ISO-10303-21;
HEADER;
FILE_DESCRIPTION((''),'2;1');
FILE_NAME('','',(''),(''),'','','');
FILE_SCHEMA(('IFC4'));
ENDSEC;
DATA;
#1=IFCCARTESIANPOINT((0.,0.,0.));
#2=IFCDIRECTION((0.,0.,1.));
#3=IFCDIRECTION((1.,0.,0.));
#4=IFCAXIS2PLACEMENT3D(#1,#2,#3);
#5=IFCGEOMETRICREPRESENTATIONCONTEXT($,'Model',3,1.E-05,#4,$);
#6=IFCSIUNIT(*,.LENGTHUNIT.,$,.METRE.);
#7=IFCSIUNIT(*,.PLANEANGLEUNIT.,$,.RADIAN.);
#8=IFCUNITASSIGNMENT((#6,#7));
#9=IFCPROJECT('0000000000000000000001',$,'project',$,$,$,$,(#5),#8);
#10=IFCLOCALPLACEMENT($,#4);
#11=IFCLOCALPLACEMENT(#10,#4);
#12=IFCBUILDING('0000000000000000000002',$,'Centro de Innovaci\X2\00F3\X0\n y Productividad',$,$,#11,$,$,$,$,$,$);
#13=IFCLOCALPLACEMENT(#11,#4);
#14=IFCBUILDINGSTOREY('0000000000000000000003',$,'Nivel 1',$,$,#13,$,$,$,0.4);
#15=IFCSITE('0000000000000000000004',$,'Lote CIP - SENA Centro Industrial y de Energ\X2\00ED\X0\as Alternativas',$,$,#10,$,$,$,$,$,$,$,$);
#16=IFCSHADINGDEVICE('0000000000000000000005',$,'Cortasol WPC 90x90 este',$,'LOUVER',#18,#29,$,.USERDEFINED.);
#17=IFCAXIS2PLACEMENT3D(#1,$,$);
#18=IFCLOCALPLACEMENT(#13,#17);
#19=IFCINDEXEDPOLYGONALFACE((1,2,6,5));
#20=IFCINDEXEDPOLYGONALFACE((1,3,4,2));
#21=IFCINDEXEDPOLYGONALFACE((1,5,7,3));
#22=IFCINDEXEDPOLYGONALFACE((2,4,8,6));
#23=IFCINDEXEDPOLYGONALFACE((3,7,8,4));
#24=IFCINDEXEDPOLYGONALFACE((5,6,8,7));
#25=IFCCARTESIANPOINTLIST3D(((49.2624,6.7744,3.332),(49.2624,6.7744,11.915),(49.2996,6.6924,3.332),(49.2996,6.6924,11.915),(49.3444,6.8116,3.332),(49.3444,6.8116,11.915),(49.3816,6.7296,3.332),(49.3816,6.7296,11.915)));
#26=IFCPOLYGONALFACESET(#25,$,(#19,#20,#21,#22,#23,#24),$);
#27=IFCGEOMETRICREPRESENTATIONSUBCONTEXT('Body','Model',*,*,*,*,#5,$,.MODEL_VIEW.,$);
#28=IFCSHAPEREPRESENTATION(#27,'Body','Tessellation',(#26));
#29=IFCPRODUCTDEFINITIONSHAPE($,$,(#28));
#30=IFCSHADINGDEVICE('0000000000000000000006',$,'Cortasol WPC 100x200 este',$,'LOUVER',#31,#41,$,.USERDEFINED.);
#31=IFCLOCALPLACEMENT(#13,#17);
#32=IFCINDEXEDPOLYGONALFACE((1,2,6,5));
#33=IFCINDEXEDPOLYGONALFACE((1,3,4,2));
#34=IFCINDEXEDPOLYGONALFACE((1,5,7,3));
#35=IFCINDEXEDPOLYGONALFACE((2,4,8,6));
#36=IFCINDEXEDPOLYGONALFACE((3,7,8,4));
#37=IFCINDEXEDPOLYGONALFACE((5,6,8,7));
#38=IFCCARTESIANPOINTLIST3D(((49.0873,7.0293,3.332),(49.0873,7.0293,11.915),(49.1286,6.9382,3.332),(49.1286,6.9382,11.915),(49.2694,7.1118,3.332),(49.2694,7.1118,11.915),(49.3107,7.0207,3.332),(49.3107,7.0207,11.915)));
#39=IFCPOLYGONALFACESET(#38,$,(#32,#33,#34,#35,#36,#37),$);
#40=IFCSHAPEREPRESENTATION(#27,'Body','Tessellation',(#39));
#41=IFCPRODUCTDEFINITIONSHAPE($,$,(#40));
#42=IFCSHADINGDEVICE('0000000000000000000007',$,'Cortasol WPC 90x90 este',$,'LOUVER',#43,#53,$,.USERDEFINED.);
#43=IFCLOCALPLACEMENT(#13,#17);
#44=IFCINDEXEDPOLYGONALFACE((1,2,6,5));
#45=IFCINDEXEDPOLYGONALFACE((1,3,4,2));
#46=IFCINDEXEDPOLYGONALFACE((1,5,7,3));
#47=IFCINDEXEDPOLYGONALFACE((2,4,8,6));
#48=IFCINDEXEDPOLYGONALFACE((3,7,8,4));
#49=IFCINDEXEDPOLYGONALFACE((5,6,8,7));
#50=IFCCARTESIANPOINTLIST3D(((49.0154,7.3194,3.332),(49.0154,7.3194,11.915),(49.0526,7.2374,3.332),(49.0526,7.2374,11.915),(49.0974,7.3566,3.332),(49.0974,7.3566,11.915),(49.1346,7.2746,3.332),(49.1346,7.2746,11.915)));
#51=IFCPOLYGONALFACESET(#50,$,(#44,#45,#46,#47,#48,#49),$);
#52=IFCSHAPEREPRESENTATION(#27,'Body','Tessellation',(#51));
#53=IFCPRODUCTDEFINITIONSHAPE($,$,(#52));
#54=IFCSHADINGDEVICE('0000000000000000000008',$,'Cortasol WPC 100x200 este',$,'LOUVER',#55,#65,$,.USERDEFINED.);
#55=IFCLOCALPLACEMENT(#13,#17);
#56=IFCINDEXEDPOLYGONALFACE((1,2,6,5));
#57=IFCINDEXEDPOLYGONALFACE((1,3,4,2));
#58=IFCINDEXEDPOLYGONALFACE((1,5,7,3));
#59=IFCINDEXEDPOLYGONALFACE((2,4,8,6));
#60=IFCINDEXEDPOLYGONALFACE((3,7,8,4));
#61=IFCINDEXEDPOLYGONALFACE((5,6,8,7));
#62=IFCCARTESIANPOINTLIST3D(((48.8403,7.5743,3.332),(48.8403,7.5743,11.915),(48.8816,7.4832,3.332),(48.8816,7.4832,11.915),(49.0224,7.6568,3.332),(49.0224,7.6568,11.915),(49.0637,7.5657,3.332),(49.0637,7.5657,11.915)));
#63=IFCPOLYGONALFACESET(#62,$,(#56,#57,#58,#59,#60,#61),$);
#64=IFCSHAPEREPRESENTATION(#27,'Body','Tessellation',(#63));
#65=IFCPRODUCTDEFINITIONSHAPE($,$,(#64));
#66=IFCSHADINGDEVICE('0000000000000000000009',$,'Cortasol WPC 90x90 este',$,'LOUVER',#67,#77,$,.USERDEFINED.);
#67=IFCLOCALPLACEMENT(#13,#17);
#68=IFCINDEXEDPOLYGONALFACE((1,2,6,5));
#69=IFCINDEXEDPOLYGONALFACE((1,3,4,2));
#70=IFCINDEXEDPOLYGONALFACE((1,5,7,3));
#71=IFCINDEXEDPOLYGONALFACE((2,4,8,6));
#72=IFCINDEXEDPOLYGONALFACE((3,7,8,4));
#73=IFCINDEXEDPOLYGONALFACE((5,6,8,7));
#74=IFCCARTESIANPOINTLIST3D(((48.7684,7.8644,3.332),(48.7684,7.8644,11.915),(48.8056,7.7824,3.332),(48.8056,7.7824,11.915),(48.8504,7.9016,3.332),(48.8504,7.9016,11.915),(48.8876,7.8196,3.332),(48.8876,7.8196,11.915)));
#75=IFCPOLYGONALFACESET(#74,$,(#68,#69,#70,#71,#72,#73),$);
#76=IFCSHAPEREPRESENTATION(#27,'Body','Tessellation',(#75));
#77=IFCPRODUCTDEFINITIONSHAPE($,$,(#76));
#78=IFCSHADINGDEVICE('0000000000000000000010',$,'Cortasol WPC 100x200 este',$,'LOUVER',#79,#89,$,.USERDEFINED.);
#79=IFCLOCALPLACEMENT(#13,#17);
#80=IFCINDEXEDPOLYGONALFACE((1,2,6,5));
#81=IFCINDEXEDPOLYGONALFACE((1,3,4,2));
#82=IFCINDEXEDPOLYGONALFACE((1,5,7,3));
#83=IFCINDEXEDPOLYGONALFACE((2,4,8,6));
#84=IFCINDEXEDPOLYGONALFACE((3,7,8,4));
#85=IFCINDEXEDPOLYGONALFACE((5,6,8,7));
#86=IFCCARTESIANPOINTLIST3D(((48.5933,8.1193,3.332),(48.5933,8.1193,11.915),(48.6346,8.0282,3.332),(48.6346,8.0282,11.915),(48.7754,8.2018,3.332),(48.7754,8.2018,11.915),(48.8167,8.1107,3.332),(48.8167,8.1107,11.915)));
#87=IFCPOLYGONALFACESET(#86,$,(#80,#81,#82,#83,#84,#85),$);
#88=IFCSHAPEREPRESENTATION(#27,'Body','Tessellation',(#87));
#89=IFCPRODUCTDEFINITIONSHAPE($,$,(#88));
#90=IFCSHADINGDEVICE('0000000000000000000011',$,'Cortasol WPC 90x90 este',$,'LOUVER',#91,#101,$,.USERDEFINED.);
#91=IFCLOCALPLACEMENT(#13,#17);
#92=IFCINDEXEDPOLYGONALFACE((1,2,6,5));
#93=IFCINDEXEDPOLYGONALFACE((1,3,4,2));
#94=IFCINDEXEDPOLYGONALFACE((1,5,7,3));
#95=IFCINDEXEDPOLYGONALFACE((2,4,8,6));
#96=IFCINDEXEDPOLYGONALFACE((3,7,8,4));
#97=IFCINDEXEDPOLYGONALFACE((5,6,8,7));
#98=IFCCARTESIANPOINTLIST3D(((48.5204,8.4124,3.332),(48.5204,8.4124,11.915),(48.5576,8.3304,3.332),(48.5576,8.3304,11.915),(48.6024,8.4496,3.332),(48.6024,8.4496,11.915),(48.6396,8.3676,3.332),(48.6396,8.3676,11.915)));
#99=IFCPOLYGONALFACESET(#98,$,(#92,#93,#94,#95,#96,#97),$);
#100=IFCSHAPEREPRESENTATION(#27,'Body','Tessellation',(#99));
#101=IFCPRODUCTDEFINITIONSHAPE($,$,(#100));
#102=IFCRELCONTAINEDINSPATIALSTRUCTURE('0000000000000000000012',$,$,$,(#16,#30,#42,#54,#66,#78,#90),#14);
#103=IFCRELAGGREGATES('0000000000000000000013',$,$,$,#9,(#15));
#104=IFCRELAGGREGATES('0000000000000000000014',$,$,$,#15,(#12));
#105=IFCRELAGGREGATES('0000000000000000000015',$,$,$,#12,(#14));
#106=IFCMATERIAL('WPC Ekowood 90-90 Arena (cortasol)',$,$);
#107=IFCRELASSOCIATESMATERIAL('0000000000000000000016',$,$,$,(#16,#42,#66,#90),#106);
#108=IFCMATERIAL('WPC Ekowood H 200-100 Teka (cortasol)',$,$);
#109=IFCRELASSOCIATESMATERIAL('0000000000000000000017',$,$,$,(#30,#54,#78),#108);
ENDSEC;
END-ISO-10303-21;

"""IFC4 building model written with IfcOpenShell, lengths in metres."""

from ifc_helpers import new_model, si_unit, frame, origin_with_axes, place, context, subcontext, project, spatial, polyline, outline, extrude, material, element, save


model = new_model("IFC4")

# Units and contexts
model_context = context("Model", 3, precision=1e-05, world=origin_with_axes())
body_context = subcontext(model_context, "Body", "Model", "MODEL_VIEW")
ifc_project = project(units=[si_unit("LENGTHUNIT", "METRE"), si_unit("PLANEANGLEUNIT", "RADIAN")], contexts=[model_context])

# Site, building, storey
site_placement = place(None, origin_with_axes())
site = spatial("IfcSite", under=ifc_project, at=site_placement, Name="Lote CIP - SENA Centro Industrial y de Energías Alternativas")
building_placement = place(site_placement, origin_with_axes())
building = spatial("IfcBuilding", under=site, at=building_placement, Name="Centro de Innovación y Productividad")
storey_placement = place(building_placement, origin_with_axes())
storey = spatial("IfcBuildingStorey", under=building, at=storey_placement, Name="Nivel 1", Elevation=0.4)

# Shading devices
ifc_material_1 = material(Name="WPC Ekowood H 200-100 Teka (cortasol)")
ifc_material_2 = material(Name="WPC Ekowood 90-90 Arena (cortasol)")
shading_device_1_placement = place(storey_placement, origin_with_axes())
element("IfcShadingDevice", 1, at=shading_device_1_placement, inside=storey, material=ifc_material_2, Name="Cortasol WPC 90x90 este", ObjectType="LOUVER", PredefinedType="USERDEFINED", context=body_context, shape_type="SweptSolid", body=[
    extrude(outline(polyline([(49.2624, 6.7744), (49.3444, 6.8116), (49.3816, 6.7296), (49.2996, 6.6924), (49.2624, 6.7744)])), frame((0.0, 0.0, 3.332)), (0.0, 0.0, 1.0), 8.583),
])
shading_device_2_placement = place(storey_placement, origin_with_axes())
element("IfcShadingDevice", 2, at=shading_device_2_placement, inside=storey, material=ifc_material_1, Name="Cortasol WPC 100x200 este", ObjectType="LOUVER", PredefinedType="USERDEFINED", context=body_context, shape_type="SweptSolid", body=[
    extrude(outline(polyline([(49.0873, 7.0293), (49.2694, 7.1118), (49.3107, 7.0207), (49.1286, 6.9382), (49.0873, 7.0293)])), frame((0.0, 0.0, 3.332)), (0.0, 0.0, 1.0), 8.583),
])
shading_device_3_placement = place(storey_placement, origin_with_axes())
element("IfcShadingDevice", 3, at=shading_device_3_placement, inside=storey, material=ifc_material_2, Name="Cortasol WPC 90x90 este", ObjectType="LOUVER", PredefinedType="USERDEFINED", context=body_context, shape_type="SweptSolid", body=[
    extrude(outline(polyline([(49.0154, 7.3194), (49.0974, 7.3566), (49.1346, 7.2746), (49.0526, 7.2374), (49.0154, 7.3194)])), frame((0.0, 0.0, 3.332)), (0.0, 0.0, 1.0), 8.583),
])
shading_device_4_placement = place(storey_placement, origin_with_axes())
element("IfcShadingDevice", 4, at=shading_device_4_placement, inside=storey, material=ifc_material_1, Name="Cortasol WPC 100x200 este", ObjectType="LOUVER", PredefinedType="USERDEFINED", context=body_context, shape_type="SweptSolid", body=[
    extrude(outline(polyline([(48.8403, 7.5743), (49.0224, 7.6568), (49.0637, 7.5657), (48.8816, 7.4832), (48.8403, 7.5743)])), frame((0.0, 0.0, 3.332)), (0.0, 0.0, 1.0), 8.583),
])
shading_device_5_placement = place(storey_placement, origin_with_axes())
element("IfcShadingDevice", 5, at=shading_device_5_placement, inside=storey, material=ifc_material_2, Name="Cortasol WPC 90x90 este", ObjectType="LOUVER", PredefinedType="USERDEFINED", context=body_context, shape_type="SweptSolid", body=[
    extrude(outline(polyline([(48.7684, 7.8644), (48.8504, 7.9016), (48.8876, 7.8196), (48.8056, 7.7824), (48.7684, 7.8644)])), frame((0.0, 0.0, 3.332)), (0.0, 0.0, 1.0), 8.583),
])
shading_device_6_placement = place(storey_placement, origin_with_axes())
element("IfcShadingDevice", 6, at=shading_device_6_placement, inside=storey, material=ifc_material_1, Name="Cortasol WPC 100x200 este", ObjectType="LOUVER", PredefinedType="USERDEFINED", context=body_context, shape_type="SweptSolid", body=[
    extrude(outline(polyline([(48.5933, 8.1193), (48.7754, 8.2018), (48.8167, 8.1107), (48.6346, 8.0282), (48.5933, 8.1193)])), frame((0.0, 0.0, 3.332)), (0.0, 0.0, 1.0), 8.583),
])
shading_device_7_placement = place(storey_placement, origin_with_axes())
element("IfcShadingDevice", 7, at=shading_device_7_placement, inside=storey, material=ifc_material_2, Name="Cortasol WPC 90x90 este", ObjectType="LOUVER", PredefinedType="USERDEFINED", context=body_context, shape_type="SweptSolid", body=[
    extrude(outline(polyline([(48.5204, 8.4124), (48.6024, 8.4496), (48.6396, 8.3676), (48.5576, 8.3304), (48.5204, 8.4124)])), frame((0.0, 0.0, 3.332)), (0.0, 0.0, 1.0), 8.583),
])

save(model, "model.ifc")
